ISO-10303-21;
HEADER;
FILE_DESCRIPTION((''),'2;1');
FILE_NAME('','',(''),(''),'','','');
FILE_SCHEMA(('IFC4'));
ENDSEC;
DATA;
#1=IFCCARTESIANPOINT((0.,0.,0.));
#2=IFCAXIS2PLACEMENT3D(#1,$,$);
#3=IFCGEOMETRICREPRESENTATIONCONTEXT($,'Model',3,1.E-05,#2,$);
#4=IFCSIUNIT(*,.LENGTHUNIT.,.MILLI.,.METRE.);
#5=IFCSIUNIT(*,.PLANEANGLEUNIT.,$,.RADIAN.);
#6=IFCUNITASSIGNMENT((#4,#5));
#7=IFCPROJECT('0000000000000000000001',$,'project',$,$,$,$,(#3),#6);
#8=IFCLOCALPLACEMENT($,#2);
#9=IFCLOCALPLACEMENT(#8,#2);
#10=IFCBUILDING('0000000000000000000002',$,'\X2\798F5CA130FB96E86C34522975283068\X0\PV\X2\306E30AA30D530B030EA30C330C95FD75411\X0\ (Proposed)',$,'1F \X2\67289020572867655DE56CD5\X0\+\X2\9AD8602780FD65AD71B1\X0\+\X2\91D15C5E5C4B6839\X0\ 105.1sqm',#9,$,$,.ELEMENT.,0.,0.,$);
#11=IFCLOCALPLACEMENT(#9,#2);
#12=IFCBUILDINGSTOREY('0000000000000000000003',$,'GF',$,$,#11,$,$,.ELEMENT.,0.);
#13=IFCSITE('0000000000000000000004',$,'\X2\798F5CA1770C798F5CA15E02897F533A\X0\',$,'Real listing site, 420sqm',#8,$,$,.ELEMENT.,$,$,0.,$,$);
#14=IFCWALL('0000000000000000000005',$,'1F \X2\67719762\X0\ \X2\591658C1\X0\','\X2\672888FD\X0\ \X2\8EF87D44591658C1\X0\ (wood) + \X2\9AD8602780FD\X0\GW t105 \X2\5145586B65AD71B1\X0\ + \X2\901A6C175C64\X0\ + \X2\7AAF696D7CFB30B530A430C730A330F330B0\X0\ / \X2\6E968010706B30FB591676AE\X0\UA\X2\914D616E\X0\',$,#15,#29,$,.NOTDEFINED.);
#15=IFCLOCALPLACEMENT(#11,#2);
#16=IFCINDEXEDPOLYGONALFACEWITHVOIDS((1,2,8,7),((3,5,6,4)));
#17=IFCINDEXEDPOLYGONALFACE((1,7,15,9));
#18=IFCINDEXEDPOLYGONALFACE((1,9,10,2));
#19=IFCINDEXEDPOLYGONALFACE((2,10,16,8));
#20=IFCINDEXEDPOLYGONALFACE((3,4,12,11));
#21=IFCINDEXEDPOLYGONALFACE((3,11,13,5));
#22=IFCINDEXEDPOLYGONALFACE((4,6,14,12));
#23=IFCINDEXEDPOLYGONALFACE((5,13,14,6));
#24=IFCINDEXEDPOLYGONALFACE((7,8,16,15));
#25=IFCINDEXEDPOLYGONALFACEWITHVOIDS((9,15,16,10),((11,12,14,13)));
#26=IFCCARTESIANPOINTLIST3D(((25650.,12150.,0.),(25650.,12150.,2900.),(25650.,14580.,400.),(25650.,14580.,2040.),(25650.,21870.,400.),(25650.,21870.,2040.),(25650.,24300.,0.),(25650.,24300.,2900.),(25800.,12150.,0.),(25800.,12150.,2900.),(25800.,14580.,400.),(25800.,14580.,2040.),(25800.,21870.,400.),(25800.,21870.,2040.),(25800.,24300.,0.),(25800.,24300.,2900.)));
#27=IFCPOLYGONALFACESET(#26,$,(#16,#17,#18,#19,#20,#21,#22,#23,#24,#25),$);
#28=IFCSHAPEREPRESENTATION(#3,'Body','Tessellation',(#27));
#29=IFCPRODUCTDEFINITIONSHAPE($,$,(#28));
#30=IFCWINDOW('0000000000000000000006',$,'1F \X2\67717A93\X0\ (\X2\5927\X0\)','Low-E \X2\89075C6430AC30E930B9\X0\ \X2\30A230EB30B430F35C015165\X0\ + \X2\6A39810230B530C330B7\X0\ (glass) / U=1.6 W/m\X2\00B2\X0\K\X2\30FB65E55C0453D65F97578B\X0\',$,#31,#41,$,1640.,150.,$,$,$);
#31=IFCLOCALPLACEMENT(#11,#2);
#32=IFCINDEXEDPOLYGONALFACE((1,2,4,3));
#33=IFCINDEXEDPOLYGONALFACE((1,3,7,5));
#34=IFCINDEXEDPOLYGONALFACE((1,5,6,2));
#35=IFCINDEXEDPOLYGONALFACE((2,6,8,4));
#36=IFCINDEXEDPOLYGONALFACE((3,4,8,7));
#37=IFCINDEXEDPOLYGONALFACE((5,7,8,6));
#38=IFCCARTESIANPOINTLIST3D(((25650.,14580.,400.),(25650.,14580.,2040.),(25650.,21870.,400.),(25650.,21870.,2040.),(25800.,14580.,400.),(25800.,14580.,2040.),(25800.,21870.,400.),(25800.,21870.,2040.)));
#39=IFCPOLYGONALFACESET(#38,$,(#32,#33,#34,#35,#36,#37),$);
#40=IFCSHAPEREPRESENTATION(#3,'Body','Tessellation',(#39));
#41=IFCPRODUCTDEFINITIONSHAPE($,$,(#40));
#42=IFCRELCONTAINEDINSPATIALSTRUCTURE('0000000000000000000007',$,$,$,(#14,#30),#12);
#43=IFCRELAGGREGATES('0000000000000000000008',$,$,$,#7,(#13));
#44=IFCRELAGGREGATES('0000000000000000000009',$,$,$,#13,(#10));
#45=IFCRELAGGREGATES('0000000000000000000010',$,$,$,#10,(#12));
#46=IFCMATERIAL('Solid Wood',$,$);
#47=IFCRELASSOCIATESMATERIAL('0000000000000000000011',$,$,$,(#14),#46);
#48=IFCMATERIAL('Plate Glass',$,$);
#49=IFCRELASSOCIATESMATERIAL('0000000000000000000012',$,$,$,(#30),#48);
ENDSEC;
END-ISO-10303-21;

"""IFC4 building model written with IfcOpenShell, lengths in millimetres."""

from ifc_helpers import new_model, si_unit, frame, frame_2d, origin, place, context, project, spatial, rectangle, extrude, material, element, fill, save


model = new_model("IFC4")

# Units and contexts
model_context = context("Model", 3, precision=1e-05, world=origin())
ifc_project = project(units=[si_unit("LENGTHUNIT", "METRE", prefix="MILLI"), si_unit("PLANEANGLEUNIT", "RADIAN")], contexts=[model_context])

# Site, building, storey
site_placement = place(None, origin())
site = spatial("IfcSite", under=ifc_project, at=site_placement, Name="福岡県福岡市西区", ObjectType="Real listing site, 420sqm", CompositionType="ELEMENT", RefElevation=0.0)
building_placement = place(site_placement, origin())
building = spatial("IfcBuilding", under=site, at=building_placement, Name="福岡・雨水利用とPVのオフグリッド志向 (Proposed)", ObjectType="1F 木造在来工法+高性能断熱+金属屋根 105.1sqm", CompositionType="ELEMENT", ElevationOfRefHeight=0.0, ElevationOfTerrain=0.0)
storey_placement = place(building_placement, origin())
storey = spatial("IfcBuildingStorey", under=building, at=storey_placement, Name="GF", CompositionType="ELEMENT", Elevation=0.0)

# Shared definitions
ifc_material_1 = material(Name="Solid Wood")

# Wall, opening, window
wall_1_placement = place(storey_placement, frame((12825.0, 6075.0, 0.0)))
wall_1 = element("IfcWall", 1, at=wall_1_placement, inside=storey, material=ifc_material_1, Name="1F 東面 外壁", Description="木製 軸組外壁 (wood) + 高性能GW t105 充填断熱 + 通気層 + 窯業系サイディング / 準耐火・外皮UA配慮", PredefinedType="NOTDEFINED", context=model_context, shape_type="SweptSolid", body=[
    extrude(rectangle(XDim=150.0, YDim=12150.0, at=frame_2d((75.0, 6075.0))), frame((12825.0, 6075.0, 0.0)), (0.0, 0.0, 1.0), 2900.0),
])
opening_placement = place(storey_placement, frame((12825.0, 7290.0, 200.0)))
opening = element("IfcOpeningElement", 2, at=opening_placement, cuts=wall_1, PredefinedType="NOTDEFINED", context=model_context, shape_type="SweptSolid", body=[
    extrude(rectangle(XDim=150.0, YDim=7290.0, at=frame_2d((75.0, 3645.0))), frame((12825.0, 7290.0, 200.0)), (0.0, 0.0, 1.0), 1640.0),
])
ifc_material_2 = material(Name="Plate Glass")
window_placement = place(storey_placement, frame((12825.0, 7290.0, 200.0)))
window = element("IfcWindow", 3, at=window_placement, inside=storey, material=ifc_material_2, Name="1F 東窓 (大)", Description="Low-E 複層ガラス アルゴン封入 + 樹脂サッシ (glass) / U=1.6 W/m²K・日射取得型", OverallHeight=1640.0, OverallWidth=150.0, context=model_context, shape_type="SweptSolid", body=[
    extrude(rectangle(XDim=150.0, YDim=7290.0, at=frame_2d((75.0, 3645.0))), frame((12825.0, 7290.0, 200.0)), (0.0, 0.0, 1.0), 1640.0),
])
fill(opening, window)

save(model, "model.ifc")
